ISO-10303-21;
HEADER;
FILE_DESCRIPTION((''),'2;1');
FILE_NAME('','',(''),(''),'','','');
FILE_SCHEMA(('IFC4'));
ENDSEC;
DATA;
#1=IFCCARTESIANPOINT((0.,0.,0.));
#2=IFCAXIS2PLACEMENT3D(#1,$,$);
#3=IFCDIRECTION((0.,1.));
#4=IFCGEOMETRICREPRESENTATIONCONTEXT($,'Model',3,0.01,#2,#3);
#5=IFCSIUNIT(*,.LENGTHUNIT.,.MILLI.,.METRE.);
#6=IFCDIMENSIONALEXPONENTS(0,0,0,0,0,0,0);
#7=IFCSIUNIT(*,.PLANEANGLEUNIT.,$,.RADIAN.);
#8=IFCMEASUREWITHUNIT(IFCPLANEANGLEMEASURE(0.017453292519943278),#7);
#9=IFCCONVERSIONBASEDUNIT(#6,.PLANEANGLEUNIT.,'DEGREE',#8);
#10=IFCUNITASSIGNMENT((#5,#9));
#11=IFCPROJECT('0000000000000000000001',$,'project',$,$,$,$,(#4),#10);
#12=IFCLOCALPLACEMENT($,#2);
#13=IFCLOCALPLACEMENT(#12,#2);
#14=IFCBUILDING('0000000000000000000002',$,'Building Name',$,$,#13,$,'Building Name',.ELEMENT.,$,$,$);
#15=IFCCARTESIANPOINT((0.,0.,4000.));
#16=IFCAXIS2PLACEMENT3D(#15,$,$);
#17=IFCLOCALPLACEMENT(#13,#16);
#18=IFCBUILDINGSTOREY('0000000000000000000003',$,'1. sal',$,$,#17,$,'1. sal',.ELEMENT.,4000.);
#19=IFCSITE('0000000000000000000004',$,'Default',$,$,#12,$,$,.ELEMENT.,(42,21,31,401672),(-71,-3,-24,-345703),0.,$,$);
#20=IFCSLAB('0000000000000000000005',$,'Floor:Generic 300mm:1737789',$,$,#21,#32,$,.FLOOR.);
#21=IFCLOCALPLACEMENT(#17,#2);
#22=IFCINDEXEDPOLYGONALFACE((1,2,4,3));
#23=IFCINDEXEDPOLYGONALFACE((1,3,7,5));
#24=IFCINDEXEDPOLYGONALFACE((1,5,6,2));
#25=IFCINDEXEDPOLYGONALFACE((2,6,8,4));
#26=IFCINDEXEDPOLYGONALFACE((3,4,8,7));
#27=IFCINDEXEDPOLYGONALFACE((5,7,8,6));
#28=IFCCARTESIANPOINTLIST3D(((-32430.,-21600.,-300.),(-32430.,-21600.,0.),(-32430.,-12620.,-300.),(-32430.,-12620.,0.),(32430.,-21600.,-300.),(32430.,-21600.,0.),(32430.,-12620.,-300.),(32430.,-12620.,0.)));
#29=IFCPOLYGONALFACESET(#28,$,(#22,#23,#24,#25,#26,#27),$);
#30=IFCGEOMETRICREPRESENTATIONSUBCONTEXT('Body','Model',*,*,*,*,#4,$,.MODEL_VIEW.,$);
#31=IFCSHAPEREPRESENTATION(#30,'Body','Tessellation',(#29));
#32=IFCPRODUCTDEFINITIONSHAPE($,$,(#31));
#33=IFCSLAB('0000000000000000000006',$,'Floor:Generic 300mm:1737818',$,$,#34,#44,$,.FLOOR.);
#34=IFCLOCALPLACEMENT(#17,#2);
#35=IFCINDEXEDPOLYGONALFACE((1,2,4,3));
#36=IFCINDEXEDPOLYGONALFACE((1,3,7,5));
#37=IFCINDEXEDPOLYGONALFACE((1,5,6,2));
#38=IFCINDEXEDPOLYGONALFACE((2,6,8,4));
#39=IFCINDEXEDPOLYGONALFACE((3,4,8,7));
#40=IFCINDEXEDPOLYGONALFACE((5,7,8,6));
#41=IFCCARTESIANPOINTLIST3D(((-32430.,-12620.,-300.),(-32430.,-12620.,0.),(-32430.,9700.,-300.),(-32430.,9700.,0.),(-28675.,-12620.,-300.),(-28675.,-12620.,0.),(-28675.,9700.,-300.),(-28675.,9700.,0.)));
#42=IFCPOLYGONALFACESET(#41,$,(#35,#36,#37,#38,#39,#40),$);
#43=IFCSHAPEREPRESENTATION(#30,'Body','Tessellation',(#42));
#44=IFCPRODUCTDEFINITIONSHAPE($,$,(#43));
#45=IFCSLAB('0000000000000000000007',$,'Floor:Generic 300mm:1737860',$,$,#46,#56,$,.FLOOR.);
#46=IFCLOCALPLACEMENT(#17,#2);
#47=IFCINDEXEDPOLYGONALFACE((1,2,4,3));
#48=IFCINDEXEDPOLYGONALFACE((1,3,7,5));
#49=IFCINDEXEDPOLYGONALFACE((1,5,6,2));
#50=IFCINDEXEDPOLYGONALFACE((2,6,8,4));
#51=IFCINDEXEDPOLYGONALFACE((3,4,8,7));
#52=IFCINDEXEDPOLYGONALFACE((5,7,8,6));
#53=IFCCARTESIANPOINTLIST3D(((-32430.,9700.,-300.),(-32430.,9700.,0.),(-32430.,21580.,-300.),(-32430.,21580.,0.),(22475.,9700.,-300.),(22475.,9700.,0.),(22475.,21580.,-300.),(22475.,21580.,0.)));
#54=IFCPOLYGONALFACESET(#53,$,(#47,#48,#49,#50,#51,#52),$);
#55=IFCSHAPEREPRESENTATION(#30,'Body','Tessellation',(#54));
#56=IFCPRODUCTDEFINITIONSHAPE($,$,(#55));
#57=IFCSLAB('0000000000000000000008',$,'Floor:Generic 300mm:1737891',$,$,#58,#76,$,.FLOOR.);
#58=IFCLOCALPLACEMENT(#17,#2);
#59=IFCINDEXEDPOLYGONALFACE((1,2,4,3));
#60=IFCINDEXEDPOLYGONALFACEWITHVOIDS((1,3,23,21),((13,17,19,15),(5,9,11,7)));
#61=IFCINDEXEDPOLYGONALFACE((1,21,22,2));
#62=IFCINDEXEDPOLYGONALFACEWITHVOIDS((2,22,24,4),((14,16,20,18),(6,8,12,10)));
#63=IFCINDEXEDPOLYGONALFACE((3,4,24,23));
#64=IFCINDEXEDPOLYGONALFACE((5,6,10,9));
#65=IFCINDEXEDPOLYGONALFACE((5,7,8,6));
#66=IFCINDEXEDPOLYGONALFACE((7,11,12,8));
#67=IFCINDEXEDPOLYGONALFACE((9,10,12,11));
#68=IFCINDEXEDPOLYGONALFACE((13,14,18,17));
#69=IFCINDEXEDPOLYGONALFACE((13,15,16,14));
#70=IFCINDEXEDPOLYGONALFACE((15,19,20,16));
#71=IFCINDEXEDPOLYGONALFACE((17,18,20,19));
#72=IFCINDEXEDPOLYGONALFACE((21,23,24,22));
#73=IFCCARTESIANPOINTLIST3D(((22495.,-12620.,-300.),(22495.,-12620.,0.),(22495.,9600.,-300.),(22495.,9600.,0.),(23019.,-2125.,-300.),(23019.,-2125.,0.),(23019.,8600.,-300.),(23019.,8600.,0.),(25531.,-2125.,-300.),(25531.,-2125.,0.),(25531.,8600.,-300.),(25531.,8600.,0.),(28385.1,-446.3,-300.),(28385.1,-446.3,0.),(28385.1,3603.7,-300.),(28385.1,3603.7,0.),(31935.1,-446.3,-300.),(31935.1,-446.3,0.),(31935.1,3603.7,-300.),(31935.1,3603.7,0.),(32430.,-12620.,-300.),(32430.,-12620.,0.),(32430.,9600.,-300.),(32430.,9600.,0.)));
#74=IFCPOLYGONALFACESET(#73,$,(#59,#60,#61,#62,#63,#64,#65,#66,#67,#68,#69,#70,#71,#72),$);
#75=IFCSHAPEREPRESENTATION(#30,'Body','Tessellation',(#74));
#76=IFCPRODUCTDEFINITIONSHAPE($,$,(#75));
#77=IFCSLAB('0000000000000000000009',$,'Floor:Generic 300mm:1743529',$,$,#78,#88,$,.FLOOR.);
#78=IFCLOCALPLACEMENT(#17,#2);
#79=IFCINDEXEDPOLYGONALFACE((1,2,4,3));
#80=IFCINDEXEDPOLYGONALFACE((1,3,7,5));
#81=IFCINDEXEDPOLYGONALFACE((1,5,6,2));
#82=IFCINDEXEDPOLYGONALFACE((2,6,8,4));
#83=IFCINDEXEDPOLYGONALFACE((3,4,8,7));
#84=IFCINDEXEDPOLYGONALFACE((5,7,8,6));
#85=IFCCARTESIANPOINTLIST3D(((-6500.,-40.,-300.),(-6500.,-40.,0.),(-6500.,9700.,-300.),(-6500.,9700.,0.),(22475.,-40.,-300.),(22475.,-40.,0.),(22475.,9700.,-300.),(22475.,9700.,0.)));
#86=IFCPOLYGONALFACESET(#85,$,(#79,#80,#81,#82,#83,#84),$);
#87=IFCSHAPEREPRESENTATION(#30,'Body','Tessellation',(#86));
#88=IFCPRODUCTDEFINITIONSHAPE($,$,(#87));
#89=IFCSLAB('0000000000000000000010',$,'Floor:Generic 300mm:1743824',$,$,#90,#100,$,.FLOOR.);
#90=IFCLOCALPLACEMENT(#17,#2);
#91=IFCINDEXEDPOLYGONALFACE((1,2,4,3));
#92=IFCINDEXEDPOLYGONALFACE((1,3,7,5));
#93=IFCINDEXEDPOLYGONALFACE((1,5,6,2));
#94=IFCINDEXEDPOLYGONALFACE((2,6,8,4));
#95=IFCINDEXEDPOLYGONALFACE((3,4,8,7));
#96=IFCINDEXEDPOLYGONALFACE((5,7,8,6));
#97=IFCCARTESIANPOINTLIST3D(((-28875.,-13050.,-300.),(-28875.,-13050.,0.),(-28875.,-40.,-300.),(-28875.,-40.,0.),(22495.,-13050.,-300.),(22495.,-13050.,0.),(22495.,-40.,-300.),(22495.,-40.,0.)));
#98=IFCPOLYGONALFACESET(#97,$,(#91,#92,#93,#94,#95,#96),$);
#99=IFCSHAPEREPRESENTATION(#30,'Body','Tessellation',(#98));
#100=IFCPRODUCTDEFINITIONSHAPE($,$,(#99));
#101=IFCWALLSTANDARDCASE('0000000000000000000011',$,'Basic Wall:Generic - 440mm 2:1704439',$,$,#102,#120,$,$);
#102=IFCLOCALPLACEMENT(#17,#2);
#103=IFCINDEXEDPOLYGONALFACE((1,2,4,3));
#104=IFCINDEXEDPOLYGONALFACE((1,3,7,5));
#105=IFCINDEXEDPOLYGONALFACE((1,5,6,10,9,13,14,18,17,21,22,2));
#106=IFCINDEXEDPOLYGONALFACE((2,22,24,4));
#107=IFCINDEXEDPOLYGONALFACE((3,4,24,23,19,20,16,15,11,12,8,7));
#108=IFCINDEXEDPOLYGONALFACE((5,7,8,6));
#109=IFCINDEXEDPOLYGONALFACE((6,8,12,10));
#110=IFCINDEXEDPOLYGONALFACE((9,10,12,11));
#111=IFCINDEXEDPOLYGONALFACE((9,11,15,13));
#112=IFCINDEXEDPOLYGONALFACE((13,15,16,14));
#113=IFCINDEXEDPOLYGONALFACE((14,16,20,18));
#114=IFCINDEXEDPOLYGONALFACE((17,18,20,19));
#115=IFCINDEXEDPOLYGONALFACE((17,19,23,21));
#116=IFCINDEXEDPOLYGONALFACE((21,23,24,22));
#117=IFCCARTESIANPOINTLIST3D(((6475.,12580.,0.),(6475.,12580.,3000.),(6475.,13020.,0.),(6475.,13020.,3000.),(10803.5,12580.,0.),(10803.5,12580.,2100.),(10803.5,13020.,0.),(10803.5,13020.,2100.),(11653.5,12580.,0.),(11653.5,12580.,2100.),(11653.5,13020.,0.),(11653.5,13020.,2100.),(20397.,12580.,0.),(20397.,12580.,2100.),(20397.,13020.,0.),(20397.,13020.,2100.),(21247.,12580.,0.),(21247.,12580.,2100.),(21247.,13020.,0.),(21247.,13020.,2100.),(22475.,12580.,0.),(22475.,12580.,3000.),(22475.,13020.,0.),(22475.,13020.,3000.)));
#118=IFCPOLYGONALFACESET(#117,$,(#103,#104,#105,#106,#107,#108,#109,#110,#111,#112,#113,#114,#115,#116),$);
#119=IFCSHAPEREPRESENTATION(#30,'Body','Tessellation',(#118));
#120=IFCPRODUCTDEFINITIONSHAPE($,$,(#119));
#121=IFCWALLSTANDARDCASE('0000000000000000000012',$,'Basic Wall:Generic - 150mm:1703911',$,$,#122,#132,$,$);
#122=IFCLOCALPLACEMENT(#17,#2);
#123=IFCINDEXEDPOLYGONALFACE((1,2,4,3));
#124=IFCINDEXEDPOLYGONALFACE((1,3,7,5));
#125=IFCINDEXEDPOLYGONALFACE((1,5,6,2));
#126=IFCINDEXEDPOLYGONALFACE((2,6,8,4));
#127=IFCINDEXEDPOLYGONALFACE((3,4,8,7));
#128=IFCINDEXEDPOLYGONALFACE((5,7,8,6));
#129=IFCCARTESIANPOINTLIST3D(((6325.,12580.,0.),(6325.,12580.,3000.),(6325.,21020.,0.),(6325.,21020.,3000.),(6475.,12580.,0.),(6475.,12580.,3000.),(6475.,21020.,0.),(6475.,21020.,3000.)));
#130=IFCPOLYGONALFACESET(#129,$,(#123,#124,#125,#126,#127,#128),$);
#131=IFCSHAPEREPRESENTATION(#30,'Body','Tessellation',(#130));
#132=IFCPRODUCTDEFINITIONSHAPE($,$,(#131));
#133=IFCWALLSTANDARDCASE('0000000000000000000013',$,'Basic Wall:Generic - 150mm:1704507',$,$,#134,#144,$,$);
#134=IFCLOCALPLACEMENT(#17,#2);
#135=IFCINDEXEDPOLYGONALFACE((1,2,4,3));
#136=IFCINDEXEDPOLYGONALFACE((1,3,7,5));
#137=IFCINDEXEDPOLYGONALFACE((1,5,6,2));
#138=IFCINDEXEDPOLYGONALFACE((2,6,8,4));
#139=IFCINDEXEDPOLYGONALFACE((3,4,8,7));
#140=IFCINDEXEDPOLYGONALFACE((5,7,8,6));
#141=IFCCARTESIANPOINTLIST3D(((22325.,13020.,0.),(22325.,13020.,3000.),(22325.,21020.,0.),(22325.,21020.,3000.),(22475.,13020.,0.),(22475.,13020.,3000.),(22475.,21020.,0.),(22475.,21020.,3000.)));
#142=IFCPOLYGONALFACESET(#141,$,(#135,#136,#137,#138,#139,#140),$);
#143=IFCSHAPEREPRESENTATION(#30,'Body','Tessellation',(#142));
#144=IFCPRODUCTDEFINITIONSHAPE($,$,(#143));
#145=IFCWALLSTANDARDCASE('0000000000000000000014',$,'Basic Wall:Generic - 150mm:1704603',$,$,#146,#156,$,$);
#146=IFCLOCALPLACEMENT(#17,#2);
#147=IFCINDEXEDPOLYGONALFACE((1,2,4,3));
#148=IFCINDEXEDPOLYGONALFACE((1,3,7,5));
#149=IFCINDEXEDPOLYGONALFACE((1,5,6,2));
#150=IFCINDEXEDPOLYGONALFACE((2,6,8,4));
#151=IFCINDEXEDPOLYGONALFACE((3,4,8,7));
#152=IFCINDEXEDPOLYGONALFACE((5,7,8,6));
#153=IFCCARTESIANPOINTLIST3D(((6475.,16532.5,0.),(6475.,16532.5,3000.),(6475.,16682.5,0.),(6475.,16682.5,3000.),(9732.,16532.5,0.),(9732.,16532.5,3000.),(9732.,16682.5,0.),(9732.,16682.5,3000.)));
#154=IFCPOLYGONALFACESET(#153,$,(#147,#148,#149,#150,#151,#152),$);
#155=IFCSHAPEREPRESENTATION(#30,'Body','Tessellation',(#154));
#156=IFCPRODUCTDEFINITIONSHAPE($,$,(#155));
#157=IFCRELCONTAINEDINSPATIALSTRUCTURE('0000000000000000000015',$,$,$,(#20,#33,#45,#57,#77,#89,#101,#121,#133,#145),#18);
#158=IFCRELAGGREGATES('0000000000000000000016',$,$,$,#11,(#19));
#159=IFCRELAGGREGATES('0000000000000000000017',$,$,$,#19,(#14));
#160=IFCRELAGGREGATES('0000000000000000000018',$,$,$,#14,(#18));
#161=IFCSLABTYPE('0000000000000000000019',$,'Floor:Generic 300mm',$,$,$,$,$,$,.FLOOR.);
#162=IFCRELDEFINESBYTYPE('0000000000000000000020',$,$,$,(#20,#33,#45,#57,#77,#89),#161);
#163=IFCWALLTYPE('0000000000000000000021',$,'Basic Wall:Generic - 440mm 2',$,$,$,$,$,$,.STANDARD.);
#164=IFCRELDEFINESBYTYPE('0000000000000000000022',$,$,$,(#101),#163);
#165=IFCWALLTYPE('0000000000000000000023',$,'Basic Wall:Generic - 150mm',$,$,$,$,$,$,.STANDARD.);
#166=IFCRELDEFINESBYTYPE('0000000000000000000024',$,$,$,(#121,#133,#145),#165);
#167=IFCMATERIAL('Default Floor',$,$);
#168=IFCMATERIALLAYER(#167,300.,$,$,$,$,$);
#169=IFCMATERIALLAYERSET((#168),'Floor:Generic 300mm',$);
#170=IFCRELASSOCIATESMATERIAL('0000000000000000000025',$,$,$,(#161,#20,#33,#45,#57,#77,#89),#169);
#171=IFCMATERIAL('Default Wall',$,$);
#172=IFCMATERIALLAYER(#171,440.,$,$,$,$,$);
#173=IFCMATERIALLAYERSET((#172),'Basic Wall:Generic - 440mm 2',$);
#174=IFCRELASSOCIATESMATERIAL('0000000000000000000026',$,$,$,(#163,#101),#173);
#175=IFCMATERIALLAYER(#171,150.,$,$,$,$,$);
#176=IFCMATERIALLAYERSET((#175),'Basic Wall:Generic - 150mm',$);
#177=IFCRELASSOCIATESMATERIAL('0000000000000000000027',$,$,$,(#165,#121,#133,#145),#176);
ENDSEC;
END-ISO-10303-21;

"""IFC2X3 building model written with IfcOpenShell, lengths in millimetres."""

from ifc_helpers import new_model, entity, si_unit, converted_unit, direction, frame, frame_2d, origin, origin_2d_with_axis, place, context, subcontext, project, spatial, rectangle, extrude, boolean, material, layer, layer_set, layer_usage, type_object, element, save


model = new_model("IFC2X3")

# Units and contexts
model_context = context("Model", 3, precision=0.01, world=origin(), true_north=direction((0.0, 1.0)))
body_context = subcontext(model_context, "Body", "Model", "MODEL_VIEW")
ifc_project = project(units=[si_unit("LENGTHUNIT", "METRE", prefix="MILLI"), converted_unit("PLANEANGLEUNIT", "DEGREE", entity("IfcPlaneAngleMeasure", 0.017453292519943278), si_unit("PLANEANGLEUNIT", "RADIAN"), dimensions=[0, 0, 0, 0, 0, 0, 0])], contexts=[model_context])

# Site, building, storey
site_placement = place(None, origin())
site = spatial("IfcSite", under=ifc_project, at=site_placement, Name="Default", CompositionType="ELEMENT", RefLatitude=(42, 21, 31, 401672), RefLongitude=(-71, -3, -24, -345703), RefElevation=0.0)
building_placement = place(site_placement, origin())
building = spatial("IfcBuilding", under=site, at=building_placement, Name="Building Name", LongName="Building Name", CompositionType="ELEMENT")
storey_placement = place(building_placement, frame((0.0, 0.0, 4000.0)))
storey = spatial("IfcBuildingStorey", under=building, at=storey_placement, Name="1. sal", LongName="1. sal", CompositionType="ELEMENT", Elevation=4000.0)

# Slabs
ifc_material_1 = material(Name="Default Floor")
ifc_layer_1 = layer(ifc_material_1, 300.0)
ifc_layer_set_1 = layer_set([ifc_layer_1], Name="Floor:Generic 300mm")
ifc_layer_usage_1 = layer_usage(ifc_layer_set_1, "AXIS3", "POSITIVE", 0.0)
slab_type = type_object("IfcSlabType", Name="Floor:Generic 300mm", PredefinedType="FLOOR", material=ifc_layer_set_1)
slab_1_placement = place(storey_placement, origin())
element("IfcSlab", 1, at=slab_1_placement, inside=storey, type_object=slab_type, material=ifc_layer_usage_1, Name="Floor:Generic 300mm:1737789", PredefinedType="FLOOR", context=body_context, shape_type="SweptSolid", body=[
    extrude(rectangle(XDim=8980.0, YDim=64860.0, at=frame_2d((0.0, 0.0), x_axis=(1.0, 0.0))), frame((0.0, -17110.0, 0.0), z_axis=(0.0, 0.0, -1.0), x_axis=(0.0, 1.0, 0.0)), (0.0, 0.0, 1.0), 300.0),
])
ifc_layer_usage_2 = layer_usage(ifc_layer_set_1, "AXIS3", "POSITIVE", 0.0)
slab_2_placement = place(storey_placement, origin())
element("IfcSlab", 2, at=slab_2_placement, inside=storey, type_object=slab_type, material=ifc_layer_usage_2, Name="Floor:Generic 300mm:1737818", PredefinedType="FLOOR", context=body_context, shape_type="SweptSolid", body=[
    extrude(rectangle(XDim=22320.0, YDim=3755.0, at=frame_2d((0.0, 0.0), x_axis=(1.0, 0.0))), frame((-30552.5, -1460.0, 0.0), z_axis=(0.0, 0.0, -1.0), x_axis=(0.0, 1.0, 0.0)), (0.0, 0.0, 1.0), 300.0),
])
ifc_layer_usage_3 = layer_usage(ifc_layer_set_1, "AXIS3", "POSITIVE", 0.0)
slab_3_placement = place(storey_placement, origin())
element("IfcSlab", 3, at=slab_3_placement, inside=storey, type_object=slab_type, material=ifc_layer_usage_3, Name="Floor:Generic 300mm:1737860", PredefinedType="FLOOR", context=body_context, shape_type="SweptSolid", body=[
    extrude(rectangle(XDim=11880.0, YDim=54905.0, at=frame_2d((0.0, 0.0), x_axis=(1.0, 0.0))), frame((-4977.5, 15640.0, 0.0), z_axis=(0.0, 0.0, -1.0), x_axis=(0.0, 1.0, 0.0)), (0.0, 0.0, 1.0), 300.0),
])

# Slab, openings
ifc_layer_usage_4 = layer_usage(ifc_layer_set_1, "AXIS3", "POSITIVE", 0.0)
slab_4_placement = place(storey_placement, origin())
slab_4 = element("IfcSlab", 4, at=slab_4_placement, inside=storey, type_object=slab_type, material=ifc_layer_usage_4, Name="Floor:Generic 300mm:1737891", PredefinedType="FLOOR", context=body_context, shape_type="CSG", body=[
    boolean("DIFFERENCE", boolean("DIFFERENCE", extrude(rectangle(XDim=22220.0, YDim=9935.0, at=frame_2d((0.0, 0.0), x_axis=(1.0, 0.0))), frame((27462.5, -1510.0, 0.0), z_axis=(0.0, 0.0, -1.0), x_axis=(0.0, 1.0, 0.0)), (0.0, 0.0, 1.0), 300.0), extrude(rectangle(XDim=10725.0, YDim=2512.0, at=origin_2d_with_axis()), frame((24275.0, 3237.5, -300.0), z_axis=(0.0, 0.0, 1.0), x_axis=(0.0, 1.0, 0.0)), (0.0, 0.0, 1.0), 300.0)), extrude(rectangle(XDim=4050.0, YDim=3550.0, at=origin_2d_with_axis()), frame((30160.1, 1578.7, 0.0), z_axis=(0.0, 0.0, -1.0), x_axis=(0.0, -1.0, 0.0)), (0.0, 0.0, 1.0), 300.0)),
])
opening_1_placement = place(slab_4_placement, origin())
element("IfcOpeningElement", 5, at=opening_1_placement, cuts=slab_4, ObjectType="Opening", context=body_context, shape_type="SweptSolid", body=[
    extrude(rectangle(XDim=4050.0, YDim=3550.0, at=frame_2d((30160.1, 1578.7), x_axis=(0.0, -1.0))), origin(), (0.0, 0.0, -1.0), 300.0),
])
opening_2_placement = place(slab_4_placement, origin())
element("IfcOpeningElement", 6, at=opening_2_placement, cuts=slab_4, ObjectType="Opening", context=body_context, shape_type="SweptSolid", body=[
    extrude(rectangle(XDim=10725.0, YDim=2512.0, at=frame_2d((24275.0, 3237.5), x_axis=(0.0, -1.0))), origin(), (0.0, 0.0, -1.0), 300.0),
])

# Slabs
ifc_layer_usage_5 = layer_usage(ifc_layer_set_1, "AXIS3", "POSITIVE", 0.0)
slab_5_placement = place(storey_placement, origin())
element("IfcSlab", 7, at=slab_5_placement, inside=storey, type_object=slab_type, material=ifc_layer_usage_5, Name="Floor:Generic 300mm:1743529", PredefinedType="FLOOR", context=body_context, shape_type="SweptSolid", body=[
    extrude(rectangle(XDim=9740.0, YDim=28975.0, at=frame_2d((0.0, 0.0), x_axis=(1.0, 0.0))), frame((7987.5, 4830.0, 0.0), z_axis=(0.0, 0.0, -1.0), x_axis=(0.0, 1.0, 0.0)), (0.0, 0.0, 1.0), 300.0),
])
ifc_layer_usage_6 = layer_usage(ifc_layer_set_1, "AXIS3", "POSITIVE", 0.0)
slab_6_placement = place(storey_placement, origin())
element("IfcSlab", 8, at=slab_6_placement, inside=storey, type_object=slab_type, material=ifc_layer_usage_6, Name="Floor:Generic 300mm:1743824", PredefinedType="FLOOR", context=body_context, shape_type="SweptSolid", body=[
    extrude(rectangle(XDim=13010.0, YDim=51370.0, at=frame_2d((0.0, 0.0), x_axis=(1.0, 0.0))), frame((-3190.0, -6545.0, 0.0), z_axis=(0.0, 0.0, -1.0), x_axis=(0.0, 1.0, 0.0)), (0.0, 0.0, 1.0), 300.0),
])

# Wall, openings
ifc_material_2 = material(Name="Default Wall")
ifc_layer_2 = layer(ifc_material_2, 440.0)
ifc_layer_set_2 = layer_set([ifc_layer_2], Name="Basic Wall:Generic - 440mm 2")
ifc_layer_usage_7 = layer_usage(ifc_layer_set_2, "AXIS2", "NEGATIVE", 220.0)
wall_type_1 = type_object("IfcWallType", Name="Basic Wall:Generic - 440mm 2", PredefinedType="STANDARD", material=ifc_layer_set_2)
wall_1_placement = place(storey_placement, frame((6475.0, 12800.0, 0.0)))
wall_1 = element("IfcWallStandardCase", 9, at=wall_1_placement, inside=storey, type_object=wall_type_1, material=ifc_layer_usage_7, Name="Basic Wall:Generic - 440mm 2:1704439", context=body_context, shape_type="SweptSolid", body=[
    extrude(rectangle(XDim=16000.0, YDim=440.0, at=frame_2d((8000.0, 0.0), x_axis=(-1.0, 0.0))), origin(), (0.0, 0.0, 1.0), 3000.0),
])
opening_3_placement = place(wall_1_placement, frame((4328.5, -220.0, 0.0)))
element("IfcOpeningElement", 10, at=opening_3_placement, cuts=wall_1, ObjectType="Opening", context=body_context, shape_type="SweptSolid", body=[
    extrude(rectangle(XDim=2100.0, YDim=850.0, at=frame_2d((1050.0, 425.0), x_axis=(1.0, 0.0))), frame((0.0, 0.0, 0.0), z_axis=(0.0, 1.0, 0.0), x_axis=(0.0, 0.0, 1.0)), (0.0, 0.0, 1.0), 440.0),
])
opening_4_placement = place(wall_1_placement, frame((13922.0, -220.0, 0.0)))
element("IfcOpeningElement", 11, at=opening_4_placement, cuts=wall_1, ObjectType="Opening", context=body_context, shape_type="SweptSolid", body=[
    extrude(rectangle(XDim=2100.0, YDim=850.0, at=frame_2d((1050.0, 425.0), x_axis=(1.0, 0.0))), frame((0.0, 0.0, 0.0), z_axis=(0.0, 1.0, 0.0), x_axis=(0.0, 0.0, 1.0)), (0.0, 0.0, 1.0), 440.0),
])

# Walls
ifc_layer_3 = layer(ifc_material_2, 150.0)
ifc_layer_set_3 = layer_set([ifc_layer_3], Name="Basic Wall:Generic - 150mm")
ifc_layer_usage_8 = layer_usage(ifc_layer_set_3, "AXIS2", "NEGATIVE", 75.0)
wall_type_2 = type_object("IfcWallType", Name="Basic Wall:Generic - 150mm", PredefinedType="STANDARD", material=ifc_layer_set_3)
wall_2_placement = place(storey_placement, frame((6400.0, 21020.0, 0.0), z_axis=(0.0, 0.0, 1.0), x_axis=(0.0, -1.0, 0.0)))
element("IfcWallStandardCase", 12, at=wall_2_placement, inside=storey, type_object=wall_type_2, material=ifc_layer_usage_8, Name="Basic Wall:Generic - 150mm:1703911", context=body_context, shape_type="SweptSolid", body=[
    extrude(rectangle(XDim=8440.0, YDim=150.0, at=frame_2d((4220.0, 0.0), x_axis=(-1.0, 0.0))), origin(), (0.0, 0.0, 1.0), 3000.0),
])
ifc_layer_usage_9 = layer_usage(ifc_layer_set_3, "AXIS2", "NEGATIVE", 75.0)
wall_3_placement = place(storey_placement, frame((22400.0, 13020.0, 0.0), z_axis=(0.0, 0.0, 1.0), x_axis=(0.0, 1.0, 0.0)))
element("IfcWallStandardCase", 13, at=wall_3_placement, inside=storey, type_object=wall_type_2, material=ifc_layer_usage_9, Name="Basic Wall:Generic - 150mm:1704507", context=body_context, shape_type="SweptSolid", body=[
    extrude(rectangle(XDim=8000.0, YDim=150.0, at=frame_2d((4000.0, 0.0), x_axis=(-1.0, 0.0))), origin(), (0.0, 0.0, 1.0), 3000.0),
])
ifc_layer_usage_10 = layer_usage(ifc_layer_set_3, "AXIS2", "NEGATIVE", 75.0)
wall_4_placement = place(storey_placement, frame((6475.0, 16607.5, 0.0)))
element("IfcWallStandardCase", 14, at=wall_4_placement, inside=storey, type_object=wall_type_2, material=ifc_layer_usage_10, Name="Basic Wall:Generic - 150mm:1704603", context=body_context, shape_type="SweptSolid", body=[
    extrude(rectangle(XDim=3257.0, YDim=150.0, at=frame_2d((1628.5, 0.0), x_axis=(-1.0, 0.0))), origin(), (0.0, 0.0, 1.0), 3000.0),
])

save(model, "model.ifc")
